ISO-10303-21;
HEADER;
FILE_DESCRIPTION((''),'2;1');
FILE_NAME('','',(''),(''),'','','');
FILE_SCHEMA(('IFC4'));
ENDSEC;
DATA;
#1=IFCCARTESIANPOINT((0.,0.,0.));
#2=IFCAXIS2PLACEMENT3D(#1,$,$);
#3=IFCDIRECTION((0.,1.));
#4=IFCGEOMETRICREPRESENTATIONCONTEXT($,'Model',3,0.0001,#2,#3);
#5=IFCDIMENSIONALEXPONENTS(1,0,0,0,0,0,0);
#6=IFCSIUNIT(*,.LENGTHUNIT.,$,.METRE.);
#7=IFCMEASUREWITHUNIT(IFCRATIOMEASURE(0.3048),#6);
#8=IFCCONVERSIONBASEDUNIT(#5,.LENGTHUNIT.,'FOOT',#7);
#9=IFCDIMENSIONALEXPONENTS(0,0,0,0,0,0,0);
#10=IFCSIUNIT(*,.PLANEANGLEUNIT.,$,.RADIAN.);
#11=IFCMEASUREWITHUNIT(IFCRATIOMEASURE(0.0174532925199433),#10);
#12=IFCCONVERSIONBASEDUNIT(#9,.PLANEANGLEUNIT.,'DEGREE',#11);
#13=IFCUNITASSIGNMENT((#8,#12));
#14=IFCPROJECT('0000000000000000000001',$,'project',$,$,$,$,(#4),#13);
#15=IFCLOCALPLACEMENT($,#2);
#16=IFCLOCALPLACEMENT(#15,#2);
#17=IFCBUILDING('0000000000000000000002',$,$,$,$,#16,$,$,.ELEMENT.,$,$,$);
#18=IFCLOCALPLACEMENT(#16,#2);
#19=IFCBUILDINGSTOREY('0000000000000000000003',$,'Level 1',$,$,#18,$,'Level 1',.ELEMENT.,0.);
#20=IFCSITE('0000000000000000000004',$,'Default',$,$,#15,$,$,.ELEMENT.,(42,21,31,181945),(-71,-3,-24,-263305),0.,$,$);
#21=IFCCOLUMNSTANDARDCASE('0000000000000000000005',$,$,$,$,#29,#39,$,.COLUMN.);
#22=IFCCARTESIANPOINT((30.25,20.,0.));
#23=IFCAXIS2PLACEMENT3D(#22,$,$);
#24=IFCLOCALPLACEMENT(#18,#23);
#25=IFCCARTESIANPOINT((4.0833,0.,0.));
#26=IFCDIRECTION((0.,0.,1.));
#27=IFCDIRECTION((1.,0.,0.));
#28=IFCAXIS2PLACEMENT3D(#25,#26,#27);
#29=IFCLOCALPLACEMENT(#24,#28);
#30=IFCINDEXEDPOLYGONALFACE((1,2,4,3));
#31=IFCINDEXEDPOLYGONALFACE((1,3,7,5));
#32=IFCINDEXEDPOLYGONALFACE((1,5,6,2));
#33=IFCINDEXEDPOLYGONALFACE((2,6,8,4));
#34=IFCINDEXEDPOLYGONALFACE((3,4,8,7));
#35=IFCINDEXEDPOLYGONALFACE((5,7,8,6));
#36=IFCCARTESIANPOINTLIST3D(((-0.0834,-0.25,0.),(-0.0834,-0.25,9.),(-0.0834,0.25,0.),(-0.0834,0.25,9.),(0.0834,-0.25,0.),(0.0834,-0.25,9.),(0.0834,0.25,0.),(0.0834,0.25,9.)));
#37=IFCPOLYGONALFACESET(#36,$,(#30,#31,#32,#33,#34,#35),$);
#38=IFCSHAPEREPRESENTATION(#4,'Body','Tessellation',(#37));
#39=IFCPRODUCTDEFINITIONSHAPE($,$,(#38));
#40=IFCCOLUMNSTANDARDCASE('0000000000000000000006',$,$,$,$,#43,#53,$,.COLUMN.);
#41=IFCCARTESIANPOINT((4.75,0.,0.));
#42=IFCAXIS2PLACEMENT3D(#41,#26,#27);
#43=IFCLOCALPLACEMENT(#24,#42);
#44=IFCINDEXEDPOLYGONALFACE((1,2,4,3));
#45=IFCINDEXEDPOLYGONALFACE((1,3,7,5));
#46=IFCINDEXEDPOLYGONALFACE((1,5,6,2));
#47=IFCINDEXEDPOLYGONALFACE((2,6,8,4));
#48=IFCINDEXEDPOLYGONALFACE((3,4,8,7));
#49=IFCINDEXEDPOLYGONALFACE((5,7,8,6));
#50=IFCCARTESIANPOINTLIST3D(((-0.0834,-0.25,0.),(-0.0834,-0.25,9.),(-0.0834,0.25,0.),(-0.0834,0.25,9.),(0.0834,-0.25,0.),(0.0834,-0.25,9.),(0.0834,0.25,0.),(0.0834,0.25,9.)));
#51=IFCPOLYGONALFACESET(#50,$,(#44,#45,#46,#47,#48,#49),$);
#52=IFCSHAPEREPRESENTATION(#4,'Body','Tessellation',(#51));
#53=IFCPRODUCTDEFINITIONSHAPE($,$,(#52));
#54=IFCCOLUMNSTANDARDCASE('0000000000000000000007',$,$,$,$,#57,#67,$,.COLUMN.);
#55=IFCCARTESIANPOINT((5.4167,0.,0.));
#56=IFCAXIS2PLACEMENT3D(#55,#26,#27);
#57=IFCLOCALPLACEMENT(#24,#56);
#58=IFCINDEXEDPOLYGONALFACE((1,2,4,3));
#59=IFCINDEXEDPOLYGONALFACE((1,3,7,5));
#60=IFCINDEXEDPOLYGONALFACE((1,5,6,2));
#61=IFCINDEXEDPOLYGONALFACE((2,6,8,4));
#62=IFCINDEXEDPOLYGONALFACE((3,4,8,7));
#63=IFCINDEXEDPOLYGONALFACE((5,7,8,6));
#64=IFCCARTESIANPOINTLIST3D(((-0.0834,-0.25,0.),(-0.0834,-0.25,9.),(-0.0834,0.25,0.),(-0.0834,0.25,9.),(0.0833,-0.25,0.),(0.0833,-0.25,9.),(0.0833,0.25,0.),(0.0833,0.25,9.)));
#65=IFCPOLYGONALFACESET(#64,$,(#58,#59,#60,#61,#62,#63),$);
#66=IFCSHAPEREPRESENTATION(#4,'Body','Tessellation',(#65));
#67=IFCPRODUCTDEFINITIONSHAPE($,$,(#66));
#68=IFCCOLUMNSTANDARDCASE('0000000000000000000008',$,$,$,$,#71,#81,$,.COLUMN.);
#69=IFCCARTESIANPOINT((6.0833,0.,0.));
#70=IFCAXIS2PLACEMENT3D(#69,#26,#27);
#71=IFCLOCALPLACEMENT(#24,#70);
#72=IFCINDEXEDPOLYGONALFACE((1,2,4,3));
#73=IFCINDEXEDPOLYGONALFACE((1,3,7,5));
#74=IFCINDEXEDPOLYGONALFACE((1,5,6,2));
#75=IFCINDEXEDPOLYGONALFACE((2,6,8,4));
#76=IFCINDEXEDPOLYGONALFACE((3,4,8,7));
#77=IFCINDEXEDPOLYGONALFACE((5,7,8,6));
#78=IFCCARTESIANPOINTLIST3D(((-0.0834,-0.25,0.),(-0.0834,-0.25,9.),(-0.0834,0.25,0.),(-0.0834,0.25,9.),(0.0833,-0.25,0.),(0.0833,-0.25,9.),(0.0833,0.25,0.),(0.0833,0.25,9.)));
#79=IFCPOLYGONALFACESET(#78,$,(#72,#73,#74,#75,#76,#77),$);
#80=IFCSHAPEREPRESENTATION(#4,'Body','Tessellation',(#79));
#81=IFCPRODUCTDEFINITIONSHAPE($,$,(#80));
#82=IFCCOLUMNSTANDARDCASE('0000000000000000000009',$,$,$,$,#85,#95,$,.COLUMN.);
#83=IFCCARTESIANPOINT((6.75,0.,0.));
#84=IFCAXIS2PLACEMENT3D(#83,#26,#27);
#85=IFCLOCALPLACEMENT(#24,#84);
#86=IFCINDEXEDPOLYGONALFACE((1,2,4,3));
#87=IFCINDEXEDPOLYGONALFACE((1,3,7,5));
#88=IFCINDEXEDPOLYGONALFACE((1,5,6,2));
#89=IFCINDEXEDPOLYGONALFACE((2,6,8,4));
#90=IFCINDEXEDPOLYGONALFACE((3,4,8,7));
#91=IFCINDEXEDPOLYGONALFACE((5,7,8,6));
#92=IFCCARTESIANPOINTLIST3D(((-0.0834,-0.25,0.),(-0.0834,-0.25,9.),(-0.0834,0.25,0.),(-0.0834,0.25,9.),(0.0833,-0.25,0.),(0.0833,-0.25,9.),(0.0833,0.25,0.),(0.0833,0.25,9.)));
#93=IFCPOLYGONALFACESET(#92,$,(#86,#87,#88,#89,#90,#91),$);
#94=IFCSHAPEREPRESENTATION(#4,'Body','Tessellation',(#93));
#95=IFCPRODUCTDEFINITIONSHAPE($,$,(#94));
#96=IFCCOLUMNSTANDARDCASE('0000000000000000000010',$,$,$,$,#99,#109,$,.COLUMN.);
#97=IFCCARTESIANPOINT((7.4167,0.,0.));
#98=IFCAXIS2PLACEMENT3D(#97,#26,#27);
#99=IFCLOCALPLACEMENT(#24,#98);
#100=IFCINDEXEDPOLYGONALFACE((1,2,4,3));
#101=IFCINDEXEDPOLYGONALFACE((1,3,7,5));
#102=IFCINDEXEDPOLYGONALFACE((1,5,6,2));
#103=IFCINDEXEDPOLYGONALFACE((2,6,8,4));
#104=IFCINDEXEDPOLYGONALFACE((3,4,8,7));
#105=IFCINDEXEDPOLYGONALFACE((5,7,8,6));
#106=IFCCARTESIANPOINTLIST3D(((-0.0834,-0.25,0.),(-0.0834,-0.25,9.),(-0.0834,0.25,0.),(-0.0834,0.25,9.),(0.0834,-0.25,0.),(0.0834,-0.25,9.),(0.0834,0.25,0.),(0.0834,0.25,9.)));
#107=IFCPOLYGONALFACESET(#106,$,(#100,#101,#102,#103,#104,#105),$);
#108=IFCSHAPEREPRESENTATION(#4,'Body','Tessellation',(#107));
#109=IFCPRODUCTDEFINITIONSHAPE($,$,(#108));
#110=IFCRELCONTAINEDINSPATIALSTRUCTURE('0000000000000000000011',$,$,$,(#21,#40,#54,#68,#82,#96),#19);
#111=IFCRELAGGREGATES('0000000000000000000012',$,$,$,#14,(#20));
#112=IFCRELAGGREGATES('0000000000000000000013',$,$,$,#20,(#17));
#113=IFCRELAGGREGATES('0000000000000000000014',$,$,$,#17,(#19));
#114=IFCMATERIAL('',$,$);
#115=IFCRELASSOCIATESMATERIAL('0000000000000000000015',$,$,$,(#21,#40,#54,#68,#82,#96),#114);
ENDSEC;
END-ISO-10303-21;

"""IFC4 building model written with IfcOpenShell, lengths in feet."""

from ifc_helpers import new_model, entity, si_unit, converted_unit, direction, frame, origin, place, context, project, spatial, rectangle, extrude, material, element, save


model = new_model("IFC4")

# Units and contexts
model_context = context("Model", 3, precision=0.0001, world=origin(), true_north=direction((0.0, 1.0)))
ifc_project = project(units=[converted_unit("LENGTHUNIT", "FOOT", entity("IfcRatioMeasure", 0.3048), si_unit("LENGTHUNIT", "METRE"), dimensions=[1, 0, 0, 0, 0, 0, 0]), converted_unit("PLANEANGLEUNIT", "DEGREE", entity("IfcRatioMeasure", 0.0174532925199433), si_unit("PLANEANGLEUNIT", "RADIAN"), dimensions=[0, 0, 0, 0, 0, 0, 0])], contexts=[model_context])

# Site, building, storey
site_placement = place(None, origin())
site = spatial("IfcSite", under=ifc_project, at=site_placement, Name="Default", CompositionType="ELEMENT", RefLatitude=(42, 21, 31, 181945), RefLongitude=(-71, -3, -24, -263305), RefElevation=0.0)
building_placement = place(site_placement, origin())
building = spatial("IfcBuilding", under=site, at=building_placement, CompositionType="ELEMENT")
storey_placement = place(building_placement, origin())
storey = spatial("IfcBuildingStorey", under=building, at=storey_placement, Name="Level 1", LongName="Level 1", CompositionType="ELEMENT", Elevation=0.0)

# Columns
ifc_material_1 = material(Name="")
wall_placement = place(storey_placement, frame((30.25, 20.0, 0.0)))
for number, where, z_axis, x_axis in (
    (1, (4.0833, 0.0, 0.0), (0.0, 0.0, 1.0), (1.0, 0.0, 0.0)),
    (2, (4.75, 0.0, 0.0), (0.0, 0.0, 1.0), (1.0, 0.0, 0.0)),
    (3, (5.4167, 0.0, 0.0), (0.0, 0.0, 1.0), (1.0, 0.0, 0.0)),
    (4, (6.0833, 0.0, 0.0), (0.0, 0.0, 1.0), (1.0, 0.0, 0.0)),
    (5, (6.75, 0.0, 0.0), (0.0, 0.0, 1.0), (1.0, 0.0, 0.0)),
    (6, (7.4167, 0.0, 0.0), (0.0, 0.0, 1.0), (1.0, 0.0, 0.0)),
):
    element("IfcColumnStandardCase", number, at=place(wall_placement, frame(where, z_axis=z_axis, x_axis=x_axis)), inside=storey, material=ifc_material_1, PredefinedType="COLUMN", context=model_context, shape_type="SweptSolid", body=[
        extrude(rectangle(XDim=0.1667, YDim=0.5), origin(), (0.0, 0.0, 1.0), 9.0),
    ])

save(model, "model.ifc")
